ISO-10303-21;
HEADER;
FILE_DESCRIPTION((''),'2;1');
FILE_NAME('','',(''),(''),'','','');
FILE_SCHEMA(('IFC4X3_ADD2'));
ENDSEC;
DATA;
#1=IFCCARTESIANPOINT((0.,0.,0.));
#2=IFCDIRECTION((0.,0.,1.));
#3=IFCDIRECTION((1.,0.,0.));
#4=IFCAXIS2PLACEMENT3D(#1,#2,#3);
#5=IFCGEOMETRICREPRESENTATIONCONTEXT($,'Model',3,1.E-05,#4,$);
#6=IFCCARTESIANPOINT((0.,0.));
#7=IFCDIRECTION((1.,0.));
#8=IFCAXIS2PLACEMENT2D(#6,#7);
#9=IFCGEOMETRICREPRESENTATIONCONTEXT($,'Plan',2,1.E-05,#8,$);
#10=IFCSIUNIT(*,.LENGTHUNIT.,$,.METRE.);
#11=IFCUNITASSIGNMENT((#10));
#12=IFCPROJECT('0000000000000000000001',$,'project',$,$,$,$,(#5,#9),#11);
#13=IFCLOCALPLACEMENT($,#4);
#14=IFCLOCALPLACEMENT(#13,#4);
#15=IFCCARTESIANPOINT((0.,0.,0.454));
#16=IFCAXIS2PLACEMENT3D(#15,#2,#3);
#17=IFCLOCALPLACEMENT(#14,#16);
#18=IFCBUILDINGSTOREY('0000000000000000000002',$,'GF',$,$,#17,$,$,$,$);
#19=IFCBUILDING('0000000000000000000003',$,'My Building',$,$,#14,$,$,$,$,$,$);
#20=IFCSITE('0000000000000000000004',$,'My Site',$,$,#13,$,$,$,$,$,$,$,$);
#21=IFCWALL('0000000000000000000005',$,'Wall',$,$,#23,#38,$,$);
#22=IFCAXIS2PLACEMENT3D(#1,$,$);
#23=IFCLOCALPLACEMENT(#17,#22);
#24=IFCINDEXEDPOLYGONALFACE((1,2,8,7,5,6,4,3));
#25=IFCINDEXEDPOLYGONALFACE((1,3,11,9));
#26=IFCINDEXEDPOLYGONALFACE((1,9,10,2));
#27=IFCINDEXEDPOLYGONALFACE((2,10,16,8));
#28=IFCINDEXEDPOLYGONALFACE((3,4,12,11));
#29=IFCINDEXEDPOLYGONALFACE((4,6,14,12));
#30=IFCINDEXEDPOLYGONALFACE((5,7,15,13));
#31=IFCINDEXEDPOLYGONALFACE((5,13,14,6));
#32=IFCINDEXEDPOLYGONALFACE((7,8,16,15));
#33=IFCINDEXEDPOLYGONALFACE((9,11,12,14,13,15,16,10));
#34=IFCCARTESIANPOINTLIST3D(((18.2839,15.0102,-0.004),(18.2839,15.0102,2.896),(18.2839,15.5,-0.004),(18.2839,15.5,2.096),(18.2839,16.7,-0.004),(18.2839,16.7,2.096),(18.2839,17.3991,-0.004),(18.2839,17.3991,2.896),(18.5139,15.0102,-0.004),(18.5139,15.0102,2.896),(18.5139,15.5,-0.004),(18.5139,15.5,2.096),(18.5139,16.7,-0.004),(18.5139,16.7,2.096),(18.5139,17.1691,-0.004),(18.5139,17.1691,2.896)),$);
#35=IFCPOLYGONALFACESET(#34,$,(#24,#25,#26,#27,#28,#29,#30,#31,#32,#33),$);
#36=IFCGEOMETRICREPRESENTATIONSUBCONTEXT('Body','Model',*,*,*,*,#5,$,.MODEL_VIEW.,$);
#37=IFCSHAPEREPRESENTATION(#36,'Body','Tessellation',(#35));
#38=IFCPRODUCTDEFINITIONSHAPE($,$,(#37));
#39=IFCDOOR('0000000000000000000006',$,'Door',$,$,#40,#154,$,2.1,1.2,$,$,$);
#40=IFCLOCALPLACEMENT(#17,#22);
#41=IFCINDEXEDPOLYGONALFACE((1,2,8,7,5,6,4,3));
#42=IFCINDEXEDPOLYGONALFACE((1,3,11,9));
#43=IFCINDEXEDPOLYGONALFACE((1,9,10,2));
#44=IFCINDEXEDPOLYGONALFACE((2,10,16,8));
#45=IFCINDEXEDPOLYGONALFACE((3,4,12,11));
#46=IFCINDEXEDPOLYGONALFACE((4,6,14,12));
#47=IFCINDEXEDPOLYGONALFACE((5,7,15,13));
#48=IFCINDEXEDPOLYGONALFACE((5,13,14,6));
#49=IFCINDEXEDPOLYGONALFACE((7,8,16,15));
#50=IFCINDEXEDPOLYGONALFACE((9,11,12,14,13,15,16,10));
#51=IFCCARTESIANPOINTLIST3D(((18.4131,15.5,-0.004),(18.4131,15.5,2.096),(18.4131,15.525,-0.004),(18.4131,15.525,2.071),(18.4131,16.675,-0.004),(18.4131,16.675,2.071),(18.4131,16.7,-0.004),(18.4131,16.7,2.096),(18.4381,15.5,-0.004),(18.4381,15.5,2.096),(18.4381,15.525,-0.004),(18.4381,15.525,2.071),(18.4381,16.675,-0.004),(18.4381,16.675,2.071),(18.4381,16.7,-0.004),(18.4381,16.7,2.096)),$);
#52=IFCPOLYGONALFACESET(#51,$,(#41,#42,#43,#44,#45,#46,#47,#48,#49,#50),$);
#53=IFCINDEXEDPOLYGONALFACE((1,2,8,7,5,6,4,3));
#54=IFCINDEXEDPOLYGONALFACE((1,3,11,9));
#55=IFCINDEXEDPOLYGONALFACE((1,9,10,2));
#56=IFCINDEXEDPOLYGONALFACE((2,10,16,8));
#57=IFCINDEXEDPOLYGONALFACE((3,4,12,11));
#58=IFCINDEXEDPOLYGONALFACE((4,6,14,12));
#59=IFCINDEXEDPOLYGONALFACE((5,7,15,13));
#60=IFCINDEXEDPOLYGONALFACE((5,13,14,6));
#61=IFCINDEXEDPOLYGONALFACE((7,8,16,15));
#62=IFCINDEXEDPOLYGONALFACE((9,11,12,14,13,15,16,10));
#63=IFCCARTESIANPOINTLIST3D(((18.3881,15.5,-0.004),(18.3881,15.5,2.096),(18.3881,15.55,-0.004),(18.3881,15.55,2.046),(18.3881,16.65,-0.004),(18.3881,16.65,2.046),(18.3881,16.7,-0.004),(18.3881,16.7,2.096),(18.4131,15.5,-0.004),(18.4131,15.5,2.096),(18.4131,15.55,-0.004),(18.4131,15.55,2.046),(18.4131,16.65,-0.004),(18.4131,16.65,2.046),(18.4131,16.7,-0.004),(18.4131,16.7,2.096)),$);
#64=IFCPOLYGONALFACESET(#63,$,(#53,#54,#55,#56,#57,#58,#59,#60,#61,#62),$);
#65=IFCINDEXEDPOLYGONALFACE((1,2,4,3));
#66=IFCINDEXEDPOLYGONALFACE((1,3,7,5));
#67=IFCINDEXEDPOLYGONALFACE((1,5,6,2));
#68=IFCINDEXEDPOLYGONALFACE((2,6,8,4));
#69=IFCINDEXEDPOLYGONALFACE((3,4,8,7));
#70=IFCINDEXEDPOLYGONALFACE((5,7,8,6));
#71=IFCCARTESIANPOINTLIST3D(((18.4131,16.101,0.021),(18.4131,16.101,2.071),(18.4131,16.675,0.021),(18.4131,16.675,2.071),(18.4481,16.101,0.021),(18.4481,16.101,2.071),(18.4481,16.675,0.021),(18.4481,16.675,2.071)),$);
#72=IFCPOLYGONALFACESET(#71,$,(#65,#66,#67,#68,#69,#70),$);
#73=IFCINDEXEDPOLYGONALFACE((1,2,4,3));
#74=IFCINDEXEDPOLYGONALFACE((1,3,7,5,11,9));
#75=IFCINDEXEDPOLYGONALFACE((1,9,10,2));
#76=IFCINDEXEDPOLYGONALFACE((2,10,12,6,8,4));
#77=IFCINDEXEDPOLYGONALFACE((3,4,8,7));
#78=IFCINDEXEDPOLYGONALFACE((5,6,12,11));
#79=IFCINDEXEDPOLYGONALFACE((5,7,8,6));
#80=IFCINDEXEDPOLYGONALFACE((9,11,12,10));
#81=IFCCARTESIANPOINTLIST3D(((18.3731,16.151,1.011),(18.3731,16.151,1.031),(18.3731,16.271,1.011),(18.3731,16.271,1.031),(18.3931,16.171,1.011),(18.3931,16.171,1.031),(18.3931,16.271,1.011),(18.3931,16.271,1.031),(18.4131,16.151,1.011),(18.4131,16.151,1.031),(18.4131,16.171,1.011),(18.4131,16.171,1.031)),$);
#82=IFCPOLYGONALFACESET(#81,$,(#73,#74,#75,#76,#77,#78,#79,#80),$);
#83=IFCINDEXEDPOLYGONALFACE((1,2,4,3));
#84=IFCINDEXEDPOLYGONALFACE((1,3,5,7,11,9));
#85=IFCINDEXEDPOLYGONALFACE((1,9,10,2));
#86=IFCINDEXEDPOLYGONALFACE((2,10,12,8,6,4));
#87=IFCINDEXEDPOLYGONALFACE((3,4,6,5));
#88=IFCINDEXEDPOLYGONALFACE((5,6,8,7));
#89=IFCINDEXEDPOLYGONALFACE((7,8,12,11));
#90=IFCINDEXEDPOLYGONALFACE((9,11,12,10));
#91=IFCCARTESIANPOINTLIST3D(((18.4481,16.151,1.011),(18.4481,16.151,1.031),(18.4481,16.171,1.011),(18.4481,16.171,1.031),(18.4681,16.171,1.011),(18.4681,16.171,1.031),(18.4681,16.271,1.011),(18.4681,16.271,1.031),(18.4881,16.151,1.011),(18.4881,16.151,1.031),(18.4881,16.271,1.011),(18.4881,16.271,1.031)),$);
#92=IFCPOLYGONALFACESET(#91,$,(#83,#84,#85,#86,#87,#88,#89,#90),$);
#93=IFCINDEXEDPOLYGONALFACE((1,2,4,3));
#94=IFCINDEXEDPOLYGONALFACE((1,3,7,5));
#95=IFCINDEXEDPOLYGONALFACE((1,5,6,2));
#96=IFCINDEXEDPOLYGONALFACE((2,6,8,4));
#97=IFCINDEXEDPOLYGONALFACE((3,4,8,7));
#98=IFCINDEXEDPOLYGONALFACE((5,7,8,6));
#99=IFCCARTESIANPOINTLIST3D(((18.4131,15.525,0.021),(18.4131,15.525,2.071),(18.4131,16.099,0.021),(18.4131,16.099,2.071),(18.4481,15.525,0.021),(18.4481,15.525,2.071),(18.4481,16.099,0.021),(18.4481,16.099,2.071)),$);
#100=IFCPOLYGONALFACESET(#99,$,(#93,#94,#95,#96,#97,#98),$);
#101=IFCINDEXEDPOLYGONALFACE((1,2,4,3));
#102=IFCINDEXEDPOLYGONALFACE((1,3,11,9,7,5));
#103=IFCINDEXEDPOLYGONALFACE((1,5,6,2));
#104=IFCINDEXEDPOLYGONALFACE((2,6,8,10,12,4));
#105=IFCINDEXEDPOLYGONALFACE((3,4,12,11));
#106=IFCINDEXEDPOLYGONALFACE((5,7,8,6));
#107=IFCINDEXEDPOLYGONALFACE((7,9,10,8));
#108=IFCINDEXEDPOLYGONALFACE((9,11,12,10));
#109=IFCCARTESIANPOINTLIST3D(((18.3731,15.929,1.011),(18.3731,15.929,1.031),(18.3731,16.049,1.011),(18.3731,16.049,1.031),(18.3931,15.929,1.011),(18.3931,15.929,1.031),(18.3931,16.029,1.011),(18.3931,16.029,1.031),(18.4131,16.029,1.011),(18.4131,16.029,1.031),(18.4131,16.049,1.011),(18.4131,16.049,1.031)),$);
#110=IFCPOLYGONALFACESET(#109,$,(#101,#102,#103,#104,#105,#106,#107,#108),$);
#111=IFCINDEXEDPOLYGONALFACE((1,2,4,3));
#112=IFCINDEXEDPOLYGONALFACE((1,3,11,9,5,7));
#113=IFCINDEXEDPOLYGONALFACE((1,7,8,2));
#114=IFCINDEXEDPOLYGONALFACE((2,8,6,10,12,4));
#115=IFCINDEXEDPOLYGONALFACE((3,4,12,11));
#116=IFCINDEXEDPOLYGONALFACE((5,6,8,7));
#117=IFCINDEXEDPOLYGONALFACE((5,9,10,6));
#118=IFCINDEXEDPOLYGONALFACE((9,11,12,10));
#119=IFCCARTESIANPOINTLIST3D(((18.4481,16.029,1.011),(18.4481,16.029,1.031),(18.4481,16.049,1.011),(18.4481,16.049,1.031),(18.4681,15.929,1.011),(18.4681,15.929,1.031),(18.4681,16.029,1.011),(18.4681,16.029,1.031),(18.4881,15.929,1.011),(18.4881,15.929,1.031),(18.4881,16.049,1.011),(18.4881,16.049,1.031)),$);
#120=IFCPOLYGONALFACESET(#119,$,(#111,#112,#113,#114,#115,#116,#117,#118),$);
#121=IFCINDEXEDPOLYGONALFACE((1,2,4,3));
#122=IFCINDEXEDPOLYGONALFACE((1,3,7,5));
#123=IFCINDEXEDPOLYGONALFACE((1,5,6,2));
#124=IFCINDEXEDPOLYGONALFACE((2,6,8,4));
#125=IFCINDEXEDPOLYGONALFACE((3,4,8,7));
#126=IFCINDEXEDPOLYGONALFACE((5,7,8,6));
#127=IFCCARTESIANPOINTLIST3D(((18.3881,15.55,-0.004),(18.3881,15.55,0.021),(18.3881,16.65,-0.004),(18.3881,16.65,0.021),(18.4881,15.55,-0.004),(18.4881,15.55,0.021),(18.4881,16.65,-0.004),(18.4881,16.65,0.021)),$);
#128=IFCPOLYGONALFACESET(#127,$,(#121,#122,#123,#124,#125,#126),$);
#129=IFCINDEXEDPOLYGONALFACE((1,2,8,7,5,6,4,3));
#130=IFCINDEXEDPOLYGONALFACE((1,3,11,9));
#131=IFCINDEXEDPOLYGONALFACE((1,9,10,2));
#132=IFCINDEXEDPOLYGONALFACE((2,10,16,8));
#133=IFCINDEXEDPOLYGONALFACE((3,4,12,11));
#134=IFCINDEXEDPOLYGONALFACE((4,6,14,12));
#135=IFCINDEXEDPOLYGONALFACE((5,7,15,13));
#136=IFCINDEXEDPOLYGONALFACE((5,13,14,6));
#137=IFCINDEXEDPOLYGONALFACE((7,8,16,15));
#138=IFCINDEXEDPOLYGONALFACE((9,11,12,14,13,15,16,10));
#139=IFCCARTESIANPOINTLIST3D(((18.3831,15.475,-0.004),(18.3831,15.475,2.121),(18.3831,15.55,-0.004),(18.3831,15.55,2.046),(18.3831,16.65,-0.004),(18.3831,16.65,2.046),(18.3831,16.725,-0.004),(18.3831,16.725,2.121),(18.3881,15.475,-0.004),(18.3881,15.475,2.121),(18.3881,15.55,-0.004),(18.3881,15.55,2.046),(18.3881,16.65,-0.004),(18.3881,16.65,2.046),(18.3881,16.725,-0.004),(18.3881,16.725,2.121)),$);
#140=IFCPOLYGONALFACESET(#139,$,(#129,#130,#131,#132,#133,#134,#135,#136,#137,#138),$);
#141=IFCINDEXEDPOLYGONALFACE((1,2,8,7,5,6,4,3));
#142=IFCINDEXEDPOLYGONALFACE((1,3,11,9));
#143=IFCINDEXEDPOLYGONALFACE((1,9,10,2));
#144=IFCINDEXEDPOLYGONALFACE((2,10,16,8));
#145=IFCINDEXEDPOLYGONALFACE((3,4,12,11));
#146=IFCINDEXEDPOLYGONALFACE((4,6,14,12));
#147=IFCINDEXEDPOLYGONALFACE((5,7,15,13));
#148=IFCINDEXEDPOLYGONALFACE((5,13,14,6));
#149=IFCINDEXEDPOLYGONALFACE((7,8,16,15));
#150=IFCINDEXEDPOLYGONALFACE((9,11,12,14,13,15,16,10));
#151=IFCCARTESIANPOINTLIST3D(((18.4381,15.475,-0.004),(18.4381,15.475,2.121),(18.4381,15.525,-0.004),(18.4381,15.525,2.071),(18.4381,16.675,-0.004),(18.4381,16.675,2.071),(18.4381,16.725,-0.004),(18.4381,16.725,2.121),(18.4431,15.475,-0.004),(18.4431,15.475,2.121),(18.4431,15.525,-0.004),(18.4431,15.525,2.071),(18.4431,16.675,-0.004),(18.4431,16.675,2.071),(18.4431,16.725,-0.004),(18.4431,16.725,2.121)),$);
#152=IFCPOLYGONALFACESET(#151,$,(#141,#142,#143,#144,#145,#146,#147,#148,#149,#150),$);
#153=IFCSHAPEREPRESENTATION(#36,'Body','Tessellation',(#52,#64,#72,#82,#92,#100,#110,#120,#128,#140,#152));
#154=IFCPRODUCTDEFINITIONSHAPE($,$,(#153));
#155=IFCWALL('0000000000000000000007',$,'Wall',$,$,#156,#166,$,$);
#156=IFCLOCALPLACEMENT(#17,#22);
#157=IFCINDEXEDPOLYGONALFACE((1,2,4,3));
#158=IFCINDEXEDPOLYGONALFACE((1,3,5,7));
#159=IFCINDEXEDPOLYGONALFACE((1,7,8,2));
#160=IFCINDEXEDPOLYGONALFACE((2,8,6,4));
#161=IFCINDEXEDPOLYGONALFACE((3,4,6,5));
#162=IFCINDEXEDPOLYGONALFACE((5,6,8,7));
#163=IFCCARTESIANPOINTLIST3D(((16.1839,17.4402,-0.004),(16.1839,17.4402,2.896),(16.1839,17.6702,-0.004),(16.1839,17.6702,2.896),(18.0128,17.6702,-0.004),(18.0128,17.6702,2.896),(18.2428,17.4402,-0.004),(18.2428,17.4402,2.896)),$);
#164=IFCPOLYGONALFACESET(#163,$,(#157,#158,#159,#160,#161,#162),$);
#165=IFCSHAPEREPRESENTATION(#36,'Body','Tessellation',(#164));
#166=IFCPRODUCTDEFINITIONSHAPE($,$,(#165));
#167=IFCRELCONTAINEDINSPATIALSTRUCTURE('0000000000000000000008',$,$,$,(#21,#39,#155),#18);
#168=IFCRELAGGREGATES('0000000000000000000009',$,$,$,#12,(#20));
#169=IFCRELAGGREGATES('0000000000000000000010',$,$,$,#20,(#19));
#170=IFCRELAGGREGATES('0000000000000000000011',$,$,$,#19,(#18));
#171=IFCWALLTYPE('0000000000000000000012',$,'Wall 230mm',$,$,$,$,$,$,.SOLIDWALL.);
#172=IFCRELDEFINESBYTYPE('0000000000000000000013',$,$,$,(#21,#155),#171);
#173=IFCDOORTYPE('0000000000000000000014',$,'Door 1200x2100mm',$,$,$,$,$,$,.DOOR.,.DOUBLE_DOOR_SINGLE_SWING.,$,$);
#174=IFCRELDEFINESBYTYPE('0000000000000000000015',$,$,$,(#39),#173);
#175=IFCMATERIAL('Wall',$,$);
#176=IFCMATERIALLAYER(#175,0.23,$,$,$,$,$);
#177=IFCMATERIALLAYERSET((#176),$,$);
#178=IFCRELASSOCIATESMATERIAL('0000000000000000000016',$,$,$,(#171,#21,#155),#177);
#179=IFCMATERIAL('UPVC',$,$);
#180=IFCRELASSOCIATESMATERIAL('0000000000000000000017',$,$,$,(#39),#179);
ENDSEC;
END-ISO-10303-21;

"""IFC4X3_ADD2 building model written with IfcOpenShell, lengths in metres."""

from ifc_helpers import new_model, entity, si_unit, frame, origin_with_axes, origin_2d_with_axis, place, context, subcontext, project, spatial, line, indexed_curve, outline, extrude, clip, halfspace, shape, source, transform, mapped, material, layer, layer_set, layer_usage, type_object, type_shapes, element, fill, save


model = new_model("IFC4X3_ADD2")

# Units and contexts
model_context = context("Model", 3, precision=1e-05, world=origin_with_axes())
plan_context = context("Plan", 2, precision=1e-05, world=origin_2d_with_axis())
body_context_1 = subcontext(model_context, "Body", "Model", "MODEL_VIEW")
body_context_2 = subcontext(plan_context, "Body", "Plan", "PLAN_VIEW")
ifc_project = project(units=[si_unit("LENGTHUNIT", "METRE")], contexts=[model_context, plan_context])

# Site, building, storey
site_placement = place(None, origin_with_axes())
site = spatial("IfcSite", under=ifc_project, at=site_placement, Name="My Site")
building_placement = place(site_placement, origin_with_axes())
building = spatial("IfcBuilding", under=site, at=building_placement, Name="My Building")
storey_placement = place(building_placement, frame((0.0, 0.0, 0.454), z_axis=(0.0, 0.0, 1.0), x_axis=(1.0, 0.0, 0.0)))
storey = spatial("IfcBuildingStorey", under=building, at=storey_placement, Name="GF")

# Shared definitions
ifc_material_1 = material(Name="Wall")
ifc_material_2 = material(Name="UPVC")

# Shared definitions
ifc_layer_1 = layer(ifc_material_1, 0.23)
ifc_layer_set_1 = layer_set([ifc_layer_1])
wall_type_1 = type_object("IfcWallType", Name="Wall 230mm", PredefinedType="SOLIDWALL", material=ifc_layer_set_1)

# Wall, opening, door
ifc_layer_usage_1 = layer_usage(ifc_layer_set_1, "AXIS2", "POSITIVE", 0.0)
wall_1_placement = place(storey_placement, frame((18.5139, 15.0102, -0.004), z_axis=(0.0, 0.0, 1.0), x_axis=(0.000001, 1.0, 0.0)))
wall_1 = element("IfcWall", 1, at=wall_1_placement, inside=storey, type_object=wall_type_1, material=ifc_layer_usage_1, Name="Wall", context=body_context_1, shape_type="Clipping", body=[
    clip(extrude(outline(indexed_curve([(0.0, 0.0), (0.0, 0.23), (2.3889, 0.23), (2.3889, 0.0), (0.0, 0.0)], self_intersect=False)), origin_with_axes(), (0.0, 0.0, 1.0), 2.9), halfspace(frame((2.1589, 0.0, -0.45), z_axis=(0.666999, -0.666993, 0.0), x_axis=(-0.707103, -0.70711, 0.0)), False)),
])
shared_shape_1 = source(origin_with_axes(), body_context_1, "Body", "SweptSolid", [
    extrude(outline(indexed_curve([(0.0, 0.0), (1.2, 0.0), (1.2, 2.1), (0.0, 2.1)], segments=[line(1, 2, 3, 4, 1)])), frame((0.0, -0.6, 0.0), z_axis=(0.0, -1.0, 0.0), x_axis=(1.0, 0.0, 0.0)), (0.0, 0.0, -1.0), 1.2),
])
opening_1_placement = place(wall_1_placement, frame((0.4898, 0.0, 0.0), z_axis=(0.0, 0.0, 1.0), x_axis=(1.0, 0.0, 0.0)))
opening_1 = element("IfcOpeningElement", 2, at=opening_1_placement, cuts=wall_1, PredefinedType="OPENING", context=body_context_1, shape_type="MappedRepresentation", body=[
    mapped(shared_shape_1, transform((0.0, 0.0, 0.0), x_axis=(1.0, 0.0, 0.0), y_axis=(0.0, 1.0, 0.0), z_axis=(0.0, 0.0, 1.0), scale=1.0)),
])
door_type_1 = type_object("IfcDoorType", Name="Door 1200x2100mm", OperationType="DOUBLE_DOOR_SINGLE_SWING", PredefinedType="DOOR")
shared_shape_2 = source(origin_with_axes(), body_context_1, "Body", "SweptSolid", [
    extrude(outline(indexed_curve([(0.0, 0.0), (0.0, 2.1), (1.2, 2.1), (1.2, 0.0), (1.175, 0.0), (1.175, 2.075), (0.025, 2.075), (0.025, 0.0)], segments=[line(1, 2, 3, 4, 5, 6, 7, 8, 1)])), frame((0.0, 0.025, 0.0), z_axis=(0.0, -1.0, 0.0), x_axis=(1.0, 0.0, 0.0)), (0.0, 0.0, -1.0), 0.025),
    extrude(outline(indexed_curve([(0.0, 0.0), (0.0, 2.1), (1.2, 2.1), (1.2, 0.0), (1.15, 0.0), (1.15, 2.05), (0.05, 2.05), (0.05, 0.0)], segments=[line(1, 2, 3, 4, 5, 6, 7, 8, 1)])), frame((0.0, 0.0, 0.0), z_axis=(0.0, -1.0, 0.0), x_axis=(1.0, 0.0, 0.0)), (0.0, 0.0, -1.0), 0.025),
    extrude(outline(indexed_curve([(0.0, 0.0), (0.574, 0.0), (0.574, 0.035), (0.0, 0.035)], segments=[line(1, 2, 3, 4, 1)])), frame((0.025, 0.025, 0.025), z_axis=(0.0, 0.0, 1.0), x_axis=(1.0, 0.0, 0.0)), (0.0, 0.0, 1.0), 2.05),
    extrude(outline(indexed_curve([(0.0, 0.0), (0.0, -0.04), (-0.12, -0.04), (-0.12, -0.02), (-0.02, -0.02), (-0.02, 0.0)], segments=[line(1, 2, 3, 4, 5, 6, 1)])), frame((0.549, 0.025, 1.015), z_axis=(0.0, 0.0, 1.0), x_axis=(1.0, 0.0, 0.0)), (0.0, 0.0, 1.0), 0.02),
    extrude(outline(indexed_curve([(0.0, 0.0), (0.0, 0.04), (-0.12, 0.04), (-0.12, 0.02), (-0.02, 0.02), (-0.02, 0.0)], segments=[line(1, 2, 3, 4, 5, 6, 1)])), frame((0.549, 0.06, 1.015), z_axis=(0.0, 0.0, 1.0), x_axis=(1.0, 0.0, 0.0)), (0.0, 0.0, 1.0), 0.02),
    extrude(outline(indexed_curve([(0.0, 0.0), (-0.574, 0.0), (-0.574, 0.035), (0.0, 0.035)], segments=[line(1, 2, 3, 4, 1)])), frame((1.175, 0.025, 0.025), z_axis=(0.0, 0.0, 1.0), x_axis=(1.0, 0.0, 0.0)), (0.0, 0.0, 1.0), 2.05),
    extrude(outline(indexed_curve([(0.0, 0.0), (0.0, -0.04), (0.12, -0.04), (0.12, -0.02), (0.02, -0.02), (0.02, 0.0)], segments=[line(1, 2, 3, 4, 5, 6, 1)])), frame((0.651, 0.025, 1.015), z_axis=(0.0, 0.0, 1.0), x_axis=(1.0, 0.0, 0.0)), (0.0, 0.0, 1.0), 0.02),
    extrude(outline(indexed_curve([(0.0, 0.0), (0.0, 0.04), (0.12, 0.04), (0.12, 0.02), (0.02, 0.02), (0.02, 0.0)], segments=[line(1, 2, 3, 4, 5, 6, 1)])), frame((0.651, 0.06, 1.015), z_axis=(0.0, 0.0, 1.0), x_axis=(1.0, 0.0, 0.0)), (0.0, 0.0, 1.0), 0.02),
    extrude(outline(indexed_curve([(0.0, 0.0), (1.1, 0.0), (1.1, 0.1), (0.0, 0.1)], segments=[line(1, 2, 3, 4, 1)])), frame((0.05, 0.0, 0.0), z_axis=(0.0, 0.0, 1.0), x_axis=(1.0, 0.0, 0.0)), (0.0, 0.0, 1.0), 0.025),
    extrude(outline(indexed_curve([(0.0, 0.0), (0.0, 2.125), (1.25, 2.125), (1.25, 0.0), (1.175, 0.0), (1.175, 2.05), (0.075, 2.05), (0.075, 0.0)], segments=[line(1, 2, 3, 4, 5, 6, 7, 8, 1)])), frame((-0.025, -0.005, 0.0), z_axis=(0.0, -1.0, 0.0), x_axis=(1.0, 0.0, 0.0)), (0.0, 0.0, -1.0), 0.005),
    extrude(outline(indexed_curve([(0.0, 0.0), (0.0, 2.125), (1.25, 2.125), (1.25, 0.0), (1.2, 0.0), (1.2, 2.075), (0.05, 2.075), (0.05, 0.0)], segments=[line(1, 2, 3, 4, 5, 6, 7, 8, 1)])), frame((-0.025, 0.05, 0.0), z_axis=(0.0, -1.0, 0.0), x_axis=(1.0, 0.0, 0.0)), (0.0, 0.0, -1.0), 0.005),
])
shared_shape_3 = source(origin_with_axes(), body_context_2, "Body", "Curve2D", [
    entity("IfcIndexedPolyCurve", entity("IfcCartesianPointList2D", [[0.0, 0.0], [0.0, 0.05], [0.025, 0.05], [0.025, 0.025], [0.05, 0.025], [0.05, 0.0]]), [entity("IfcLineIndex", [1, 2, 3, 4, 5, 6, 1])]),
    entity("IfcIndexedPolyCurve", entity("IfcCartesianPointList2D", [[1.2, 0.0], [1.2, 0.05], [1.175, 0.05], [1.175, 0.025], [1.15, 0.025], [1.15, 0.0]]), [entity("IfcLineIndex", [1, 2, 3, 4, 5, 6, 1])]),
    entity("IfcTrimmedCurve", entity("IfcEllipse", entity("IfcAxis2Placement2D", entity("IfcCartesianPoint", [0.06, 0.05]), entity("IfcDirection", [1.0, 0.0])), 0.54, 0.575), [entity("IfcCartesianPoint", [0.6, 0.05])], [entity("IfcCartesianPoint", [0.06, 0.625])], True, "CARTESIAN"),
    entity("IfcIndexedPolyCurve", entity("IfcCartesianPointList2D", [[0.025, 0.05], [0.06, 0.05], [0.06, 0.625], [0.025, 0.625]]), [entity("IfcLineIndex", [1, 2, 3, 4, 1])]),
    entity("IfcTrimmedCurve", entity("IfcEllipse", entity("IfcAxis2Placement2D", entity("IfcCartesianPoint", [1.14, 0.05]), entity("IfcDirection", [1.0, 0.0])), 0.54, 0.575), [entity("IfcCartesianPoint", [1.14, 0.625])], [entity("IfcCartesianPoint", [0.6, 0.05])], True, "CARTESIAN"),
    entity("IfcIndexedPolyCurve", entity("IfcCartesianPointList2D", [[1.175, 0.05], [1.14, 0.05], [1.14, 0.625], [1.175, 0.625]]), [entity("IfcLineIndex", [1, 2, 3, 4, 1])]),
])
type_shapes(door_type_1, [shared_shape_2, shared_shape_3])
door_1_placement = place(opening_1_placement, frame((1.2, 0.1258, 0.0), z_axis=(0.0, 0.0, 1.0), x_axis=(-1.0, 0.0, 0.0)))
door_1 = element("IfcDoor", 3, at=door_1_placement, inside=storey, type_object=door_type_1, material=ifc_material_2, Name="Door", OverallHeight=2.1, OverallWidth=1.2, shapes=[
    shape(body_context_1, "Body", "MappedRepresentation", [mapped(shared_shape_2, transform((0.0, 0.0, 0.0), x_axis=(1.0, 0.0, 0.0), y_axis=(0.0, 1.0, 0.0), z_axis=(0.0, 0.0, 1.0), scale=1.0))]),
    shape(body_context_2, "Body", "MappedRepresentation", [mapped(shared_shape_3, transform((0.0, 0.0, 0.0), x_axis=(1.0, 0.0, 0.0), y_axis=(0.0, 1.0, 0.0), z_axis=(0.0, 0.0, 1.0), scale=1.0))]),
])
fill(opening_1, door_1)

# Wall
ifc_layer_usage_2 = layer_usage(ifc_layer_set_1, "AXIS2", "POSITIVE", 0.0)
wall_2_placement = place(storey_placement, frame((18.2428, 17.6702, -0.004), z_axis=(0.0, 0.0, 1.0), x_axis=(-1.0, 0.0, 0.0)))
element("IfcWall", 4, at=wall_2_placement, inside=storey, type_object=wall_type_1, material=ifc_layer_usage_2, Name="Wall", context=body_context_1, shape_type="Clipping", body=[
    clip(extrude(outline(indexed_curve([(0.0, 0.0), (0.0, 0.23), (2.0589, 0.23), (2.0589, 0.0), (0.0, 0.0)], self_intersect=False)), origin_with_axes(), (0.0, 0.0, 1.0), 2.9), halfspace(frame((0.23, 0.0, -0.45), z_axis=(-0.666999, -0.666999, 0.0), x_axis=(-0.707107, 0.707107, 0.0)), False)),
])

save(model, "model.ifc")
